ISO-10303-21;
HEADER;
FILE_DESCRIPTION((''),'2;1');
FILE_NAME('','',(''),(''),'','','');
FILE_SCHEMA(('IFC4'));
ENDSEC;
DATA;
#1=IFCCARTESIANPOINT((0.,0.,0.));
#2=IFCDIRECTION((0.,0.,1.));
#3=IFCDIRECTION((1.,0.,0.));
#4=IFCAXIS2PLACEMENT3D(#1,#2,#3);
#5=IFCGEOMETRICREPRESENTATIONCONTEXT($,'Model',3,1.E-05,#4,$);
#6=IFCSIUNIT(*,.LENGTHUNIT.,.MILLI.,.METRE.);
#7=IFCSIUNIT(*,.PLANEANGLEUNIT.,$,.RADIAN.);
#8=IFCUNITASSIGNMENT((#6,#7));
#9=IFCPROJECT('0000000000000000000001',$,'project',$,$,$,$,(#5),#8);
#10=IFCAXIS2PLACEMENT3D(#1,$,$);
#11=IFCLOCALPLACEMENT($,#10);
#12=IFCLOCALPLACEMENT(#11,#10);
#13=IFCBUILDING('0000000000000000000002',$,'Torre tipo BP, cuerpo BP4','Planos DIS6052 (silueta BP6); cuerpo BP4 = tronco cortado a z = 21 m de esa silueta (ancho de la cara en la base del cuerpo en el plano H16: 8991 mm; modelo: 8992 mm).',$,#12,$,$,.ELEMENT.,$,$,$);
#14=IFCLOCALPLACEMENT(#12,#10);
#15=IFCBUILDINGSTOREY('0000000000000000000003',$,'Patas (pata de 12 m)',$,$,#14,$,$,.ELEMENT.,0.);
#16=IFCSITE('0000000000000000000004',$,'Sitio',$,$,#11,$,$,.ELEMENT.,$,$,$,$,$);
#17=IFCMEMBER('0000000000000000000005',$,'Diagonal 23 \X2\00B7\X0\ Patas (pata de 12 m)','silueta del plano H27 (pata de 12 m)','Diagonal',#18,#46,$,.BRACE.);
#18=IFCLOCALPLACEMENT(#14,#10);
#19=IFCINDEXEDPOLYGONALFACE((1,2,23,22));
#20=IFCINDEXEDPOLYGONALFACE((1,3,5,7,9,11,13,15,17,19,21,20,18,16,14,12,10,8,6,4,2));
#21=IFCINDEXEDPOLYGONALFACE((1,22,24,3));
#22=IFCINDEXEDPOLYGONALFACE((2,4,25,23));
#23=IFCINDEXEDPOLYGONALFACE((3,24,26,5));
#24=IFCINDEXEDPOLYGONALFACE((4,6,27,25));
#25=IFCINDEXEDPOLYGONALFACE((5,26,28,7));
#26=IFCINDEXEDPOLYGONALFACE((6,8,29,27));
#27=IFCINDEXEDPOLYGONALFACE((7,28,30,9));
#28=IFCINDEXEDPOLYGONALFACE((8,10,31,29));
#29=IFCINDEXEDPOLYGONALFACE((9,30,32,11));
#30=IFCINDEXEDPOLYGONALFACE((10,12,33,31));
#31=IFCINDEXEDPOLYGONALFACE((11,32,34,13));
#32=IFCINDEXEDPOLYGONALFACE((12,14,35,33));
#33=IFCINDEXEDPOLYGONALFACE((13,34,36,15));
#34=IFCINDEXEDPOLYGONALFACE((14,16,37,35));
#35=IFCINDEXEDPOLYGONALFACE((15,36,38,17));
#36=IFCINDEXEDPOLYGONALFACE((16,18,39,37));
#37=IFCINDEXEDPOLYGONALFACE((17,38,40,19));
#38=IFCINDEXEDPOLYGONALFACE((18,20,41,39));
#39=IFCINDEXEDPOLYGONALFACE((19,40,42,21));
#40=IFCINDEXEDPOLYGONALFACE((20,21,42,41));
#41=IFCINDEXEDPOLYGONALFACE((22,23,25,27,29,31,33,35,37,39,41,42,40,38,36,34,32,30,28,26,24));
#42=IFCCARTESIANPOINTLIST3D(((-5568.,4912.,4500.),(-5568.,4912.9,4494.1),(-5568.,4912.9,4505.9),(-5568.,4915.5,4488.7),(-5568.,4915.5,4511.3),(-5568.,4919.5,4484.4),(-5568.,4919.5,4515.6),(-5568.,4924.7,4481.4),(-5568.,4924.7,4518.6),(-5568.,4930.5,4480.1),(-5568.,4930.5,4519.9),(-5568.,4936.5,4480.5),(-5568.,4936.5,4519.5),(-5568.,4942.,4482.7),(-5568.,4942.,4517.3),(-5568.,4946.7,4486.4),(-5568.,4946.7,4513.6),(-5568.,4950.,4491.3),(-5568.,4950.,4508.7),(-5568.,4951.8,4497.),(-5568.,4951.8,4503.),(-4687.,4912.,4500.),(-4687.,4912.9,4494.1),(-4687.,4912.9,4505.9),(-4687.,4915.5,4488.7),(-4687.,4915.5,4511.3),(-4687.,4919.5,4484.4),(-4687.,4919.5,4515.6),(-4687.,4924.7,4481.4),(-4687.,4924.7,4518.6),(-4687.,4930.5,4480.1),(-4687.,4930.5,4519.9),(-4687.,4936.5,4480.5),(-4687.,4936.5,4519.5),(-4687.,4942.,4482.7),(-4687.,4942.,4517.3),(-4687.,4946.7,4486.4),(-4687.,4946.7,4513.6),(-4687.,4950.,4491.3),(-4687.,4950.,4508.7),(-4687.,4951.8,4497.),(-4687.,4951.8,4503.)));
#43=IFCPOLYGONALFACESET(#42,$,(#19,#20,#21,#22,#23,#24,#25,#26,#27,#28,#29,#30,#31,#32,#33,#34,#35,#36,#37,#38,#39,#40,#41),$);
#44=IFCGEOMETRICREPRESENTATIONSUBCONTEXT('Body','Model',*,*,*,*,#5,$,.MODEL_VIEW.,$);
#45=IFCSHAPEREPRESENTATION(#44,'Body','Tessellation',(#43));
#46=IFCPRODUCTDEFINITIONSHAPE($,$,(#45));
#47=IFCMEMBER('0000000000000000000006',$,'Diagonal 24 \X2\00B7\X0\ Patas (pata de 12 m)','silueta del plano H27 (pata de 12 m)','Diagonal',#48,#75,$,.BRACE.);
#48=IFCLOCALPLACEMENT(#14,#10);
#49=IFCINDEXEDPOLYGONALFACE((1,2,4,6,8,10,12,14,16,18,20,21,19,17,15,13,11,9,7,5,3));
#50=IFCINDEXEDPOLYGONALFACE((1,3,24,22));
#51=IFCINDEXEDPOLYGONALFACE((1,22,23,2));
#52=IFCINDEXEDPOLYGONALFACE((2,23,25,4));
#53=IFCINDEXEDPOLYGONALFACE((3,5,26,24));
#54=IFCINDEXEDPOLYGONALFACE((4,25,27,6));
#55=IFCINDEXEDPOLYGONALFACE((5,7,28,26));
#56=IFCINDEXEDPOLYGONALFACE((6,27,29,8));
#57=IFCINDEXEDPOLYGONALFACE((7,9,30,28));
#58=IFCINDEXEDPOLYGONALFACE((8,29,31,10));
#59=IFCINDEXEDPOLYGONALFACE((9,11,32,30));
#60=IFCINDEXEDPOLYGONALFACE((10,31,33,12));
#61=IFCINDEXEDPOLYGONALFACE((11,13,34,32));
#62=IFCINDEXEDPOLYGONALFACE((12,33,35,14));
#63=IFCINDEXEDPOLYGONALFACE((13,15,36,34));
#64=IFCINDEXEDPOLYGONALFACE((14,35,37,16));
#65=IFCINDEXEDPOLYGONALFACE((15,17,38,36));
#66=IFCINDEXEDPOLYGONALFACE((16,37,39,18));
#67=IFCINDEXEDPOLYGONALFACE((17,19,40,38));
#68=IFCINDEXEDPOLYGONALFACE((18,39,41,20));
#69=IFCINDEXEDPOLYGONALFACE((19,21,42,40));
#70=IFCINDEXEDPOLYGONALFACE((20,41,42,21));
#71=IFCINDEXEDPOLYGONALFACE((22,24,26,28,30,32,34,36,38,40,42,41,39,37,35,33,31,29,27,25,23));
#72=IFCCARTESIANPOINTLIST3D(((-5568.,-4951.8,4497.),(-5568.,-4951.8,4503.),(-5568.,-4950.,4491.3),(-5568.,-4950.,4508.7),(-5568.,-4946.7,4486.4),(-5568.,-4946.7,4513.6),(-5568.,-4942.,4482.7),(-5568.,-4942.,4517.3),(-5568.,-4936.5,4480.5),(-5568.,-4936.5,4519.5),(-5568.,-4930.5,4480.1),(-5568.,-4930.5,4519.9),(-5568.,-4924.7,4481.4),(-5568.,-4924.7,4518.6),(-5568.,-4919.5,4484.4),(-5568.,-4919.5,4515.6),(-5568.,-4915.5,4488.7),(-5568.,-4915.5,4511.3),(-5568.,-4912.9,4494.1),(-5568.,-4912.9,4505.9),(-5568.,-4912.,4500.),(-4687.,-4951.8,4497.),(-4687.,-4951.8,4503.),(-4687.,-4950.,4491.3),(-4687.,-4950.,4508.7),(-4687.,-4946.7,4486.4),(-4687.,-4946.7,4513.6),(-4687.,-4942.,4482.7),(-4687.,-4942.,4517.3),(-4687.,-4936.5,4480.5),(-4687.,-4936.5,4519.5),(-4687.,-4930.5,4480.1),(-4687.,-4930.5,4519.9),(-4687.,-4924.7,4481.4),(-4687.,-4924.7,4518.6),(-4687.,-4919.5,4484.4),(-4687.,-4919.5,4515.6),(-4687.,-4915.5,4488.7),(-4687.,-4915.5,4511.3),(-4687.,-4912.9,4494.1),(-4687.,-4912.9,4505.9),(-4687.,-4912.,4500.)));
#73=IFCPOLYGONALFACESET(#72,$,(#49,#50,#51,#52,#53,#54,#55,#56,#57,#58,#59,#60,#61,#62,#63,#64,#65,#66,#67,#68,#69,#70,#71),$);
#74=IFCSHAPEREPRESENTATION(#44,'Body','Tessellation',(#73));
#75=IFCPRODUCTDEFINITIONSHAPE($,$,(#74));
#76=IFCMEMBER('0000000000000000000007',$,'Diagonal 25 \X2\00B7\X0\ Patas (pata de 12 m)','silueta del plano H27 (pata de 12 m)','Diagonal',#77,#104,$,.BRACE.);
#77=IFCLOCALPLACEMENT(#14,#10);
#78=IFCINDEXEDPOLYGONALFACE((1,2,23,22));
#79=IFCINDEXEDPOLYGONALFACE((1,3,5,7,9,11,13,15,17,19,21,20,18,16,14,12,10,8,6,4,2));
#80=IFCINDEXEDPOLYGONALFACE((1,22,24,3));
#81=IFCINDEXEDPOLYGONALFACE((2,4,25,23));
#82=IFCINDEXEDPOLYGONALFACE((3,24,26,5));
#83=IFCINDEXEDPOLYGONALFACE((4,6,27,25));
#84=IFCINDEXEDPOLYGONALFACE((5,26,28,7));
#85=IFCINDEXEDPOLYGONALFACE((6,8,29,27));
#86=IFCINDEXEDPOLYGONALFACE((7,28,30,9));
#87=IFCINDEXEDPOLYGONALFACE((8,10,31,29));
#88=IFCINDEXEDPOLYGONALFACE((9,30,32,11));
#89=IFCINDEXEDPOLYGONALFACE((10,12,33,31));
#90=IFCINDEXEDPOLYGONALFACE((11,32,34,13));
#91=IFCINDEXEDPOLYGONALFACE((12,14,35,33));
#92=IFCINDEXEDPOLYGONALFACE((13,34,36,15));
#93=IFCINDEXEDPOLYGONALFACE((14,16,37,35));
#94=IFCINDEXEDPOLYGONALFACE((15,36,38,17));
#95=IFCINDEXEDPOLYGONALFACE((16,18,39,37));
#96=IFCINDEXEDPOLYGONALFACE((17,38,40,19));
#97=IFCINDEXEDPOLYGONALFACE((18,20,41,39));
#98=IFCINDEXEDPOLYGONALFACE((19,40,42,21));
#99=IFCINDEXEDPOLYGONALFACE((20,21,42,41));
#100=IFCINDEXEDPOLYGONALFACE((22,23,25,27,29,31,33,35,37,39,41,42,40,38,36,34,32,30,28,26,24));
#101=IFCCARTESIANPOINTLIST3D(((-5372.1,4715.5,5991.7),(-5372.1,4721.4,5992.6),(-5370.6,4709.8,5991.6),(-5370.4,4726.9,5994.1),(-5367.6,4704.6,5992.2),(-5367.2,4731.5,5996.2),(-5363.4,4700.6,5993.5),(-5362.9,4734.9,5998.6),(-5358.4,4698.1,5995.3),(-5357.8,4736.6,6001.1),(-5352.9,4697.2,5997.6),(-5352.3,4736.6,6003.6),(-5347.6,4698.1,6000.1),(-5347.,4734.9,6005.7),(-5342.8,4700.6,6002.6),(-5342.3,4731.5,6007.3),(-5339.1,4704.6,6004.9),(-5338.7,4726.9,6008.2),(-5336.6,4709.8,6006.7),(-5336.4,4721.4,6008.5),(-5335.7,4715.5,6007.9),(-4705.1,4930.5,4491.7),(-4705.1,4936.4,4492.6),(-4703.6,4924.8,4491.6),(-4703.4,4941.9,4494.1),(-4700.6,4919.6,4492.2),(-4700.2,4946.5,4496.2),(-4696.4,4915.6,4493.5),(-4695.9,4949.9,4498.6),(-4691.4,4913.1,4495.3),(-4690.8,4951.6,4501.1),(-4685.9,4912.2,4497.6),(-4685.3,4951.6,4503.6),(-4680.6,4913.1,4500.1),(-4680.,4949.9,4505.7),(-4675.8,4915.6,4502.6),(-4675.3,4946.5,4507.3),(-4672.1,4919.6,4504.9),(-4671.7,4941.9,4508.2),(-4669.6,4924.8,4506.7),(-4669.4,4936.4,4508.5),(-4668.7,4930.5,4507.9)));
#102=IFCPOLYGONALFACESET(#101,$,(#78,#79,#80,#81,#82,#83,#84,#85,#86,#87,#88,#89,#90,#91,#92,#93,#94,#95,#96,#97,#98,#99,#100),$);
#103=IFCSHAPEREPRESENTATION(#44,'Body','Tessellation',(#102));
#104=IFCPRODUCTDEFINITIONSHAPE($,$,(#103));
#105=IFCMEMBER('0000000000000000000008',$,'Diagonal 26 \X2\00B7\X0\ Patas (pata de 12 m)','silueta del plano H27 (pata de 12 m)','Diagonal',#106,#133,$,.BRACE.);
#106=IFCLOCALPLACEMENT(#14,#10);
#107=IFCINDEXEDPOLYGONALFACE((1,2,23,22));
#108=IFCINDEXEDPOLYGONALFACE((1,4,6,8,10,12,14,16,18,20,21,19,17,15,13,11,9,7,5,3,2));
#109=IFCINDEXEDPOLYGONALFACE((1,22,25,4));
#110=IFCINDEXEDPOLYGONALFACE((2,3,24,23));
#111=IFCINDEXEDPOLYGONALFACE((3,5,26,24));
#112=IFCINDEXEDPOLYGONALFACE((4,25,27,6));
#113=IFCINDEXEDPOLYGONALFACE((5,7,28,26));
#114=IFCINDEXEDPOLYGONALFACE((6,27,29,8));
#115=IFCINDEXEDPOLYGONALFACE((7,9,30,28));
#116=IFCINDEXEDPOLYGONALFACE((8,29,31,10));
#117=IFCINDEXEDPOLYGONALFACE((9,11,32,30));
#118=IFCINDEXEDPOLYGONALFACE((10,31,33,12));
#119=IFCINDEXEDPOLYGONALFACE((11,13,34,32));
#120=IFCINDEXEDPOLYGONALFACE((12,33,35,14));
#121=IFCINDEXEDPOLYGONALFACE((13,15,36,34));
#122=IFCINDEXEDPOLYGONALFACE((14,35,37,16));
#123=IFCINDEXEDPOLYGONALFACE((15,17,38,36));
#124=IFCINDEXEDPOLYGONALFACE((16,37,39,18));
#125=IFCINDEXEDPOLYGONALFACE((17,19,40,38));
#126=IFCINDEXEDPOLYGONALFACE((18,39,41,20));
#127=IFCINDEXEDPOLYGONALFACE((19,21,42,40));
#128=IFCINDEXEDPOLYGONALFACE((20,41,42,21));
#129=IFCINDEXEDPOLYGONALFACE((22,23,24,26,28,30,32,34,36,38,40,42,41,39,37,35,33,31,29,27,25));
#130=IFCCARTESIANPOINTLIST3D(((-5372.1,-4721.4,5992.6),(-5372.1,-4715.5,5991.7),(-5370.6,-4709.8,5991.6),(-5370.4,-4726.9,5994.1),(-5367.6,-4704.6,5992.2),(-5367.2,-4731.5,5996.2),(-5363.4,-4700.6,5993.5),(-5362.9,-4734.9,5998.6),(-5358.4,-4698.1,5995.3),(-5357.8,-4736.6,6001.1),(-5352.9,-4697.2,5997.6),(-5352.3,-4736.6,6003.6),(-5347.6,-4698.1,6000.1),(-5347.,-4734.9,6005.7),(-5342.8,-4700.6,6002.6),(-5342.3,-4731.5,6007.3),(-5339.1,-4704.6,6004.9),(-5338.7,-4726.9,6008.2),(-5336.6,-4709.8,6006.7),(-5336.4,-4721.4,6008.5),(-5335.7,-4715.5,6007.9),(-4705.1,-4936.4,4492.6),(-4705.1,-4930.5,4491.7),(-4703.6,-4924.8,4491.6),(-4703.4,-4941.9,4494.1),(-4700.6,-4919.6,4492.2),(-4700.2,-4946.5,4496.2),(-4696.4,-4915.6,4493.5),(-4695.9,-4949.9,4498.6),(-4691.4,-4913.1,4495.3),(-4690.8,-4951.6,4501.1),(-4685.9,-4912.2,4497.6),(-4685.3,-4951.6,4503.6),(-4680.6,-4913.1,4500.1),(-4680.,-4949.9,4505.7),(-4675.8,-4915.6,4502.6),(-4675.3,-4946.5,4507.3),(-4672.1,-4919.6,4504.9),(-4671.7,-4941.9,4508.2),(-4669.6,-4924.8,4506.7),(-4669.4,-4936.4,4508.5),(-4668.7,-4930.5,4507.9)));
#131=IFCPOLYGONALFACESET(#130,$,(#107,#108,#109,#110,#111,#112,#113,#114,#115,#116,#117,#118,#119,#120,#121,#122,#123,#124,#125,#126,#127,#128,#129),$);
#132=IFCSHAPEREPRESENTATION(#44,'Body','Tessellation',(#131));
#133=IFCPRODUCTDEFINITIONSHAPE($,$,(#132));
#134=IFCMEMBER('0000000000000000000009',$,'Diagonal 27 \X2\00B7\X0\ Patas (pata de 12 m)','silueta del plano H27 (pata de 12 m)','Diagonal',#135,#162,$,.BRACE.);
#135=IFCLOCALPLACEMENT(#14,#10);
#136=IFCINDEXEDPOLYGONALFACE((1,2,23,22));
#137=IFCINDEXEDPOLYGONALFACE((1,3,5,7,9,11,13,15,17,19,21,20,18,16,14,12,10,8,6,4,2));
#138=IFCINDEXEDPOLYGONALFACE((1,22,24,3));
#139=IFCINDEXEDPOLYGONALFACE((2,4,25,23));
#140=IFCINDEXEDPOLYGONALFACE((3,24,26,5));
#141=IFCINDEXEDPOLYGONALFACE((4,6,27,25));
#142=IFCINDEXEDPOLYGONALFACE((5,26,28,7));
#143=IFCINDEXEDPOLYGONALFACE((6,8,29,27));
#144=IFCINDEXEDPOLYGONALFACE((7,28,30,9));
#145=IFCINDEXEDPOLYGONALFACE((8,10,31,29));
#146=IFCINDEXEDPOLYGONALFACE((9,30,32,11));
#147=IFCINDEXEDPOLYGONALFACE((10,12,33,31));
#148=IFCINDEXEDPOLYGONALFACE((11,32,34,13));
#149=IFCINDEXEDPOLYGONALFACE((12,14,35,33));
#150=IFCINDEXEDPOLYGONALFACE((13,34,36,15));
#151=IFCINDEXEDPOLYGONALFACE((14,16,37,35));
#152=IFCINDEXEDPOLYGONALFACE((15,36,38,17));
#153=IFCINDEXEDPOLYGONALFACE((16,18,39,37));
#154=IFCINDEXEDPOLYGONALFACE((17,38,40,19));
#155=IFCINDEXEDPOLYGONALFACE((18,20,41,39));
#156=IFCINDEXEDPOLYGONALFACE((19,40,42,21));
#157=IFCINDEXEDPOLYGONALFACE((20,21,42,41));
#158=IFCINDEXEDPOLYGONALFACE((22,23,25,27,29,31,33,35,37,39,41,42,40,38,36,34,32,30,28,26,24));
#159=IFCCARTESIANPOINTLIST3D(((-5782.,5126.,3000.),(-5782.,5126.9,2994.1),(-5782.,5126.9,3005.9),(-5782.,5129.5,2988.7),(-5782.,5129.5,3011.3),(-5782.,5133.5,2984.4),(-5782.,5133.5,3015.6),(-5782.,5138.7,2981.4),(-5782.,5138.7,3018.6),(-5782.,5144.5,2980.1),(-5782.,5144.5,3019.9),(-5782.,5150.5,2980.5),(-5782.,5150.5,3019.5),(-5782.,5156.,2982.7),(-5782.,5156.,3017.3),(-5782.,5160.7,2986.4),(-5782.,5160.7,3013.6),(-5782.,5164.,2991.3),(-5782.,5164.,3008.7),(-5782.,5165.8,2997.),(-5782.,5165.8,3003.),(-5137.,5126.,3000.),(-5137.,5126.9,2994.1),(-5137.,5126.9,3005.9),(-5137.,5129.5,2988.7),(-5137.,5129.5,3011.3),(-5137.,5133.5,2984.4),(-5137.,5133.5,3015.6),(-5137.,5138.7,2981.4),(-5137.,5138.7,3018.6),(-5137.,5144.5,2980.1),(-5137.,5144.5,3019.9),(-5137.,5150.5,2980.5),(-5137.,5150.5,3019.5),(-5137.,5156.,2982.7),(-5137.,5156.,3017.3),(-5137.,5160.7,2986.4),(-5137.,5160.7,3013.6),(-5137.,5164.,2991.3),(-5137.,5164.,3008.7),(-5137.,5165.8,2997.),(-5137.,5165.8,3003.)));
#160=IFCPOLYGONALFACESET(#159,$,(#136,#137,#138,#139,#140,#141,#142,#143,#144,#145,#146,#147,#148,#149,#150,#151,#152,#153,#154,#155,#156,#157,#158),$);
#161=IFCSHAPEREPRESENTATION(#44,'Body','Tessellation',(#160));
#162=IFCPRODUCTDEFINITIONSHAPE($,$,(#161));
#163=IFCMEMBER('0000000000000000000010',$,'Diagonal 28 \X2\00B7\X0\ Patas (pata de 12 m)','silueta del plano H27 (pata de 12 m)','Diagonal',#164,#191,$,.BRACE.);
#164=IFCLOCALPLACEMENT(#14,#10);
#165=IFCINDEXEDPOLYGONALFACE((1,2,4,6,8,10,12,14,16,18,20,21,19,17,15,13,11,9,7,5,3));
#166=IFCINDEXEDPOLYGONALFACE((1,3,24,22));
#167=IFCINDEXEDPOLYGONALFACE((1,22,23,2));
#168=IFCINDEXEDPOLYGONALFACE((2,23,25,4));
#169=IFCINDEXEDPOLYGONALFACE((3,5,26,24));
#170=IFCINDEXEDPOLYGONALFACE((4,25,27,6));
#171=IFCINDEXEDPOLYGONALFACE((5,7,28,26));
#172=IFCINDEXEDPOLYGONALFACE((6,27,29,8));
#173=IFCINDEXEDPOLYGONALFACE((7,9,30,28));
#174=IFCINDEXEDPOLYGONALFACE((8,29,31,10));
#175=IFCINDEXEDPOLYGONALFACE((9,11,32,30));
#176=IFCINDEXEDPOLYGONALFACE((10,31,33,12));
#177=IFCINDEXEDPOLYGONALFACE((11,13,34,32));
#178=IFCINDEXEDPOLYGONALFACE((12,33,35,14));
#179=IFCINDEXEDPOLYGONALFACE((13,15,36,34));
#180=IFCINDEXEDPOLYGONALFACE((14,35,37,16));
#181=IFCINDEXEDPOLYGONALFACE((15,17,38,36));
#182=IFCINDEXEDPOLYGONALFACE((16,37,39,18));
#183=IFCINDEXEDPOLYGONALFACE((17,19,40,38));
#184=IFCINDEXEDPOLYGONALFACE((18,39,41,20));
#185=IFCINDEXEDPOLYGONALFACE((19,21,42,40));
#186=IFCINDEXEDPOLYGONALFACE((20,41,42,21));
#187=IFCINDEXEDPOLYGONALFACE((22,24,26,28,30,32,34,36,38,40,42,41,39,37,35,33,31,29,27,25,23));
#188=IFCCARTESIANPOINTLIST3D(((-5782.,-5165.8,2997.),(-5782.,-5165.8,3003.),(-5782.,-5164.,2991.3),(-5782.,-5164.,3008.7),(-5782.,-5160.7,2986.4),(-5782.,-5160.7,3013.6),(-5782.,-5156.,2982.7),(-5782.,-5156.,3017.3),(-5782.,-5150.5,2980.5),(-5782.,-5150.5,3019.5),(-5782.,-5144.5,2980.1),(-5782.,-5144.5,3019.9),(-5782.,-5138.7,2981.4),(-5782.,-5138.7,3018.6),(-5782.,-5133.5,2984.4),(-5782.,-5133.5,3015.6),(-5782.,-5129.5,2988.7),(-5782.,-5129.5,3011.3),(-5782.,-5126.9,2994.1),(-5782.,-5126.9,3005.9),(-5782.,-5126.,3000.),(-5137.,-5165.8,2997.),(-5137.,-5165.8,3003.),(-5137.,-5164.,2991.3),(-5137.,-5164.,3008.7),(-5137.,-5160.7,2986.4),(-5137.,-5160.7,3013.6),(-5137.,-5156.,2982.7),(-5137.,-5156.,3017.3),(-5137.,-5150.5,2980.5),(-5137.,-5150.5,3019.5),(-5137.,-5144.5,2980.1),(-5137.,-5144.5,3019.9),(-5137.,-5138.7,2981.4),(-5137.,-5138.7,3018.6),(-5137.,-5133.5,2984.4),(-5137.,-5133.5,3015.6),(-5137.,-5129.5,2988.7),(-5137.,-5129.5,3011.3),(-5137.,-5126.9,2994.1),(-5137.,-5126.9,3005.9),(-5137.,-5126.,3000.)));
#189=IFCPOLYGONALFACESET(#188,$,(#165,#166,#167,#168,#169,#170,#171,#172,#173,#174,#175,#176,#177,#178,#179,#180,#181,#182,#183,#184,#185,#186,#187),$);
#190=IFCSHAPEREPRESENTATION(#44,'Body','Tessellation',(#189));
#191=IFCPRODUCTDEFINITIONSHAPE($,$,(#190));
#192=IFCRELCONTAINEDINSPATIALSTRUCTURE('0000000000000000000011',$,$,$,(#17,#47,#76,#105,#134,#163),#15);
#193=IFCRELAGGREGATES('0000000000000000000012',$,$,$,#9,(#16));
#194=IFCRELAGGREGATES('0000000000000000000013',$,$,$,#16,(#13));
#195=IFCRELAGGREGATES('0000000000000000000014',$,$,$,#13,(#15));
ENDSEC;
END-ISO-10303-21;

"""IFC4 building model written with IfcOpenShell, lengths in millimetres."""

from ifc_helpers import new_model, si_unit, frame, origin, origin_with_axes, place, context, subcontext, project, spatial, circle, extrude, element, save


model = new_model("IFC4")

# Units and contexts
model_context = context("Model", 3, precision=1e-05, world=origin_with_axes())
body_context = subcontext(model_context, "Body", "Model", "MODEL_VIEW")
ifc_project = project(units=[si_unit("LENGTHUNIT", "METRE", prefix="MILLI"), si_unit("PLANEANGLEUNIT", "RADIAN")], contexts=[model_context])

# Site, building, storey
site_placement = place(None, origin())
site = spatial("IfcSite", under=ifc_project, at=site_placement, Name="Sitio", CompositionType="ELEMENT")
building_placement = place(site_placement, origin())
building = spatial("IfcBuilding", under=site, at=building_placement, Name="Torre tipo BP, cuerpo BP4", Description="Planos DIS6052 (silueta BP6); cuerpo BP4 = tronco cortado a z = 21 m de esa silueta (ancho de la cara en la base del cuerpo en el plano H16: 8991 mm; modelo: 8992 mm).", CompositionType="ELEMENT")
storey_placement = place(building_placement, origin())
storey = spatial("IfcBuildingStorey", under=building, at=storey_placement, Name="Patas (pata de 12 m)", CompositionType="ELEMENT", Elevation=0.0)

# Members
for number, where, z_axis, x_axis, name in (
    (1, (-5568.0, 4932.0, 4500.0), (1.0, 0.0, 0.0), (0.0, -1.0, 0.0), "Diagonal 23 · Patas (pata de 12 m)"),
    (2, (-5568.0, -4932.0, 4500.0), (1.0, 0.0, 0.0), (0.0, 1.0, 0.0), "Diagonal 24 · Patas (pata de 12 m)"),
):
    element("IfcMember", number, at=place(storey_placement, frame(where, z_axis=z_axis, x_axis=x_axis)), inside=storey, Name=name, Description="silueta del plano H27 (pata de 12 m)", ObjectType="Diagonal", PredefinedType="BRACE", context=body_context, shape_type="SweptSolid", body=[
        extrude(circle(Radius=20.0), None, (0.0, 0.0, 1.0), 881.0),
    ])
for number, where, z_axis, x_axis, name in (
    (3, (-4687.0, 4932.0, 4500.0), (-0.402868, -0.12986, 0.905999), (0.052763, -0.991532, -0.118658), "Diagonal 25 · Patas (pata de 12 m)"),
    (4, (-4687.0, -4932.0, 4500.0), (-0.402868, 0.12986, 0.905999), (0.052763, 0.991532, -0.118658), "Diagonal 26 · Patas (pata de 12 m)"),
):
    element("IfcMember", number, at=place(storey_placement, frame(where, z_axis=z_axis, x_axis=x_axis)), inside=storey, Name=name, Description="silueta del plano H27 (pata de 12 m)", ObjectType="Diagonal", PredefinedType="BRACE", context=body_context, shape_type="SweptSolid", body=[
        extrude(circle(Radius=20.0), None, (0.0, 0.0, 1.0), 1655.6),
    ])
for number, where, z_axis, x_axis, name in (
    (5, (-5782.0, 5146.0, 3000.0), (1.0, 0.0, 0.0), (0.0, -1.0, 0.0), "Diagonal 27 · Patas (pata de 12 m)"),
    (6, (-5782.0, -5146.0, 3000.0), (1.0, 0.0, 0.0), (0.0, 1.0, 0.0), "Diagonal 28 · Patas (pata de 12 m)"),
):
    element("IfcMember", number, at=place(storey_placement, frame(where, z_axis=z_axis, x_axis=x_axis)), inside=storey, Name=name, Description="silueta del plano H27 (pata de 12 m)", ObjectType="Diagonal", PredefinedType="BRACE", context=body_context, shape_type="SweptSolid", body=[
        extrude(circle(Radius=20.0), None, (0.0, 0.0, 1.0), 645.0),
    ])

save(model, "model.ifc")
